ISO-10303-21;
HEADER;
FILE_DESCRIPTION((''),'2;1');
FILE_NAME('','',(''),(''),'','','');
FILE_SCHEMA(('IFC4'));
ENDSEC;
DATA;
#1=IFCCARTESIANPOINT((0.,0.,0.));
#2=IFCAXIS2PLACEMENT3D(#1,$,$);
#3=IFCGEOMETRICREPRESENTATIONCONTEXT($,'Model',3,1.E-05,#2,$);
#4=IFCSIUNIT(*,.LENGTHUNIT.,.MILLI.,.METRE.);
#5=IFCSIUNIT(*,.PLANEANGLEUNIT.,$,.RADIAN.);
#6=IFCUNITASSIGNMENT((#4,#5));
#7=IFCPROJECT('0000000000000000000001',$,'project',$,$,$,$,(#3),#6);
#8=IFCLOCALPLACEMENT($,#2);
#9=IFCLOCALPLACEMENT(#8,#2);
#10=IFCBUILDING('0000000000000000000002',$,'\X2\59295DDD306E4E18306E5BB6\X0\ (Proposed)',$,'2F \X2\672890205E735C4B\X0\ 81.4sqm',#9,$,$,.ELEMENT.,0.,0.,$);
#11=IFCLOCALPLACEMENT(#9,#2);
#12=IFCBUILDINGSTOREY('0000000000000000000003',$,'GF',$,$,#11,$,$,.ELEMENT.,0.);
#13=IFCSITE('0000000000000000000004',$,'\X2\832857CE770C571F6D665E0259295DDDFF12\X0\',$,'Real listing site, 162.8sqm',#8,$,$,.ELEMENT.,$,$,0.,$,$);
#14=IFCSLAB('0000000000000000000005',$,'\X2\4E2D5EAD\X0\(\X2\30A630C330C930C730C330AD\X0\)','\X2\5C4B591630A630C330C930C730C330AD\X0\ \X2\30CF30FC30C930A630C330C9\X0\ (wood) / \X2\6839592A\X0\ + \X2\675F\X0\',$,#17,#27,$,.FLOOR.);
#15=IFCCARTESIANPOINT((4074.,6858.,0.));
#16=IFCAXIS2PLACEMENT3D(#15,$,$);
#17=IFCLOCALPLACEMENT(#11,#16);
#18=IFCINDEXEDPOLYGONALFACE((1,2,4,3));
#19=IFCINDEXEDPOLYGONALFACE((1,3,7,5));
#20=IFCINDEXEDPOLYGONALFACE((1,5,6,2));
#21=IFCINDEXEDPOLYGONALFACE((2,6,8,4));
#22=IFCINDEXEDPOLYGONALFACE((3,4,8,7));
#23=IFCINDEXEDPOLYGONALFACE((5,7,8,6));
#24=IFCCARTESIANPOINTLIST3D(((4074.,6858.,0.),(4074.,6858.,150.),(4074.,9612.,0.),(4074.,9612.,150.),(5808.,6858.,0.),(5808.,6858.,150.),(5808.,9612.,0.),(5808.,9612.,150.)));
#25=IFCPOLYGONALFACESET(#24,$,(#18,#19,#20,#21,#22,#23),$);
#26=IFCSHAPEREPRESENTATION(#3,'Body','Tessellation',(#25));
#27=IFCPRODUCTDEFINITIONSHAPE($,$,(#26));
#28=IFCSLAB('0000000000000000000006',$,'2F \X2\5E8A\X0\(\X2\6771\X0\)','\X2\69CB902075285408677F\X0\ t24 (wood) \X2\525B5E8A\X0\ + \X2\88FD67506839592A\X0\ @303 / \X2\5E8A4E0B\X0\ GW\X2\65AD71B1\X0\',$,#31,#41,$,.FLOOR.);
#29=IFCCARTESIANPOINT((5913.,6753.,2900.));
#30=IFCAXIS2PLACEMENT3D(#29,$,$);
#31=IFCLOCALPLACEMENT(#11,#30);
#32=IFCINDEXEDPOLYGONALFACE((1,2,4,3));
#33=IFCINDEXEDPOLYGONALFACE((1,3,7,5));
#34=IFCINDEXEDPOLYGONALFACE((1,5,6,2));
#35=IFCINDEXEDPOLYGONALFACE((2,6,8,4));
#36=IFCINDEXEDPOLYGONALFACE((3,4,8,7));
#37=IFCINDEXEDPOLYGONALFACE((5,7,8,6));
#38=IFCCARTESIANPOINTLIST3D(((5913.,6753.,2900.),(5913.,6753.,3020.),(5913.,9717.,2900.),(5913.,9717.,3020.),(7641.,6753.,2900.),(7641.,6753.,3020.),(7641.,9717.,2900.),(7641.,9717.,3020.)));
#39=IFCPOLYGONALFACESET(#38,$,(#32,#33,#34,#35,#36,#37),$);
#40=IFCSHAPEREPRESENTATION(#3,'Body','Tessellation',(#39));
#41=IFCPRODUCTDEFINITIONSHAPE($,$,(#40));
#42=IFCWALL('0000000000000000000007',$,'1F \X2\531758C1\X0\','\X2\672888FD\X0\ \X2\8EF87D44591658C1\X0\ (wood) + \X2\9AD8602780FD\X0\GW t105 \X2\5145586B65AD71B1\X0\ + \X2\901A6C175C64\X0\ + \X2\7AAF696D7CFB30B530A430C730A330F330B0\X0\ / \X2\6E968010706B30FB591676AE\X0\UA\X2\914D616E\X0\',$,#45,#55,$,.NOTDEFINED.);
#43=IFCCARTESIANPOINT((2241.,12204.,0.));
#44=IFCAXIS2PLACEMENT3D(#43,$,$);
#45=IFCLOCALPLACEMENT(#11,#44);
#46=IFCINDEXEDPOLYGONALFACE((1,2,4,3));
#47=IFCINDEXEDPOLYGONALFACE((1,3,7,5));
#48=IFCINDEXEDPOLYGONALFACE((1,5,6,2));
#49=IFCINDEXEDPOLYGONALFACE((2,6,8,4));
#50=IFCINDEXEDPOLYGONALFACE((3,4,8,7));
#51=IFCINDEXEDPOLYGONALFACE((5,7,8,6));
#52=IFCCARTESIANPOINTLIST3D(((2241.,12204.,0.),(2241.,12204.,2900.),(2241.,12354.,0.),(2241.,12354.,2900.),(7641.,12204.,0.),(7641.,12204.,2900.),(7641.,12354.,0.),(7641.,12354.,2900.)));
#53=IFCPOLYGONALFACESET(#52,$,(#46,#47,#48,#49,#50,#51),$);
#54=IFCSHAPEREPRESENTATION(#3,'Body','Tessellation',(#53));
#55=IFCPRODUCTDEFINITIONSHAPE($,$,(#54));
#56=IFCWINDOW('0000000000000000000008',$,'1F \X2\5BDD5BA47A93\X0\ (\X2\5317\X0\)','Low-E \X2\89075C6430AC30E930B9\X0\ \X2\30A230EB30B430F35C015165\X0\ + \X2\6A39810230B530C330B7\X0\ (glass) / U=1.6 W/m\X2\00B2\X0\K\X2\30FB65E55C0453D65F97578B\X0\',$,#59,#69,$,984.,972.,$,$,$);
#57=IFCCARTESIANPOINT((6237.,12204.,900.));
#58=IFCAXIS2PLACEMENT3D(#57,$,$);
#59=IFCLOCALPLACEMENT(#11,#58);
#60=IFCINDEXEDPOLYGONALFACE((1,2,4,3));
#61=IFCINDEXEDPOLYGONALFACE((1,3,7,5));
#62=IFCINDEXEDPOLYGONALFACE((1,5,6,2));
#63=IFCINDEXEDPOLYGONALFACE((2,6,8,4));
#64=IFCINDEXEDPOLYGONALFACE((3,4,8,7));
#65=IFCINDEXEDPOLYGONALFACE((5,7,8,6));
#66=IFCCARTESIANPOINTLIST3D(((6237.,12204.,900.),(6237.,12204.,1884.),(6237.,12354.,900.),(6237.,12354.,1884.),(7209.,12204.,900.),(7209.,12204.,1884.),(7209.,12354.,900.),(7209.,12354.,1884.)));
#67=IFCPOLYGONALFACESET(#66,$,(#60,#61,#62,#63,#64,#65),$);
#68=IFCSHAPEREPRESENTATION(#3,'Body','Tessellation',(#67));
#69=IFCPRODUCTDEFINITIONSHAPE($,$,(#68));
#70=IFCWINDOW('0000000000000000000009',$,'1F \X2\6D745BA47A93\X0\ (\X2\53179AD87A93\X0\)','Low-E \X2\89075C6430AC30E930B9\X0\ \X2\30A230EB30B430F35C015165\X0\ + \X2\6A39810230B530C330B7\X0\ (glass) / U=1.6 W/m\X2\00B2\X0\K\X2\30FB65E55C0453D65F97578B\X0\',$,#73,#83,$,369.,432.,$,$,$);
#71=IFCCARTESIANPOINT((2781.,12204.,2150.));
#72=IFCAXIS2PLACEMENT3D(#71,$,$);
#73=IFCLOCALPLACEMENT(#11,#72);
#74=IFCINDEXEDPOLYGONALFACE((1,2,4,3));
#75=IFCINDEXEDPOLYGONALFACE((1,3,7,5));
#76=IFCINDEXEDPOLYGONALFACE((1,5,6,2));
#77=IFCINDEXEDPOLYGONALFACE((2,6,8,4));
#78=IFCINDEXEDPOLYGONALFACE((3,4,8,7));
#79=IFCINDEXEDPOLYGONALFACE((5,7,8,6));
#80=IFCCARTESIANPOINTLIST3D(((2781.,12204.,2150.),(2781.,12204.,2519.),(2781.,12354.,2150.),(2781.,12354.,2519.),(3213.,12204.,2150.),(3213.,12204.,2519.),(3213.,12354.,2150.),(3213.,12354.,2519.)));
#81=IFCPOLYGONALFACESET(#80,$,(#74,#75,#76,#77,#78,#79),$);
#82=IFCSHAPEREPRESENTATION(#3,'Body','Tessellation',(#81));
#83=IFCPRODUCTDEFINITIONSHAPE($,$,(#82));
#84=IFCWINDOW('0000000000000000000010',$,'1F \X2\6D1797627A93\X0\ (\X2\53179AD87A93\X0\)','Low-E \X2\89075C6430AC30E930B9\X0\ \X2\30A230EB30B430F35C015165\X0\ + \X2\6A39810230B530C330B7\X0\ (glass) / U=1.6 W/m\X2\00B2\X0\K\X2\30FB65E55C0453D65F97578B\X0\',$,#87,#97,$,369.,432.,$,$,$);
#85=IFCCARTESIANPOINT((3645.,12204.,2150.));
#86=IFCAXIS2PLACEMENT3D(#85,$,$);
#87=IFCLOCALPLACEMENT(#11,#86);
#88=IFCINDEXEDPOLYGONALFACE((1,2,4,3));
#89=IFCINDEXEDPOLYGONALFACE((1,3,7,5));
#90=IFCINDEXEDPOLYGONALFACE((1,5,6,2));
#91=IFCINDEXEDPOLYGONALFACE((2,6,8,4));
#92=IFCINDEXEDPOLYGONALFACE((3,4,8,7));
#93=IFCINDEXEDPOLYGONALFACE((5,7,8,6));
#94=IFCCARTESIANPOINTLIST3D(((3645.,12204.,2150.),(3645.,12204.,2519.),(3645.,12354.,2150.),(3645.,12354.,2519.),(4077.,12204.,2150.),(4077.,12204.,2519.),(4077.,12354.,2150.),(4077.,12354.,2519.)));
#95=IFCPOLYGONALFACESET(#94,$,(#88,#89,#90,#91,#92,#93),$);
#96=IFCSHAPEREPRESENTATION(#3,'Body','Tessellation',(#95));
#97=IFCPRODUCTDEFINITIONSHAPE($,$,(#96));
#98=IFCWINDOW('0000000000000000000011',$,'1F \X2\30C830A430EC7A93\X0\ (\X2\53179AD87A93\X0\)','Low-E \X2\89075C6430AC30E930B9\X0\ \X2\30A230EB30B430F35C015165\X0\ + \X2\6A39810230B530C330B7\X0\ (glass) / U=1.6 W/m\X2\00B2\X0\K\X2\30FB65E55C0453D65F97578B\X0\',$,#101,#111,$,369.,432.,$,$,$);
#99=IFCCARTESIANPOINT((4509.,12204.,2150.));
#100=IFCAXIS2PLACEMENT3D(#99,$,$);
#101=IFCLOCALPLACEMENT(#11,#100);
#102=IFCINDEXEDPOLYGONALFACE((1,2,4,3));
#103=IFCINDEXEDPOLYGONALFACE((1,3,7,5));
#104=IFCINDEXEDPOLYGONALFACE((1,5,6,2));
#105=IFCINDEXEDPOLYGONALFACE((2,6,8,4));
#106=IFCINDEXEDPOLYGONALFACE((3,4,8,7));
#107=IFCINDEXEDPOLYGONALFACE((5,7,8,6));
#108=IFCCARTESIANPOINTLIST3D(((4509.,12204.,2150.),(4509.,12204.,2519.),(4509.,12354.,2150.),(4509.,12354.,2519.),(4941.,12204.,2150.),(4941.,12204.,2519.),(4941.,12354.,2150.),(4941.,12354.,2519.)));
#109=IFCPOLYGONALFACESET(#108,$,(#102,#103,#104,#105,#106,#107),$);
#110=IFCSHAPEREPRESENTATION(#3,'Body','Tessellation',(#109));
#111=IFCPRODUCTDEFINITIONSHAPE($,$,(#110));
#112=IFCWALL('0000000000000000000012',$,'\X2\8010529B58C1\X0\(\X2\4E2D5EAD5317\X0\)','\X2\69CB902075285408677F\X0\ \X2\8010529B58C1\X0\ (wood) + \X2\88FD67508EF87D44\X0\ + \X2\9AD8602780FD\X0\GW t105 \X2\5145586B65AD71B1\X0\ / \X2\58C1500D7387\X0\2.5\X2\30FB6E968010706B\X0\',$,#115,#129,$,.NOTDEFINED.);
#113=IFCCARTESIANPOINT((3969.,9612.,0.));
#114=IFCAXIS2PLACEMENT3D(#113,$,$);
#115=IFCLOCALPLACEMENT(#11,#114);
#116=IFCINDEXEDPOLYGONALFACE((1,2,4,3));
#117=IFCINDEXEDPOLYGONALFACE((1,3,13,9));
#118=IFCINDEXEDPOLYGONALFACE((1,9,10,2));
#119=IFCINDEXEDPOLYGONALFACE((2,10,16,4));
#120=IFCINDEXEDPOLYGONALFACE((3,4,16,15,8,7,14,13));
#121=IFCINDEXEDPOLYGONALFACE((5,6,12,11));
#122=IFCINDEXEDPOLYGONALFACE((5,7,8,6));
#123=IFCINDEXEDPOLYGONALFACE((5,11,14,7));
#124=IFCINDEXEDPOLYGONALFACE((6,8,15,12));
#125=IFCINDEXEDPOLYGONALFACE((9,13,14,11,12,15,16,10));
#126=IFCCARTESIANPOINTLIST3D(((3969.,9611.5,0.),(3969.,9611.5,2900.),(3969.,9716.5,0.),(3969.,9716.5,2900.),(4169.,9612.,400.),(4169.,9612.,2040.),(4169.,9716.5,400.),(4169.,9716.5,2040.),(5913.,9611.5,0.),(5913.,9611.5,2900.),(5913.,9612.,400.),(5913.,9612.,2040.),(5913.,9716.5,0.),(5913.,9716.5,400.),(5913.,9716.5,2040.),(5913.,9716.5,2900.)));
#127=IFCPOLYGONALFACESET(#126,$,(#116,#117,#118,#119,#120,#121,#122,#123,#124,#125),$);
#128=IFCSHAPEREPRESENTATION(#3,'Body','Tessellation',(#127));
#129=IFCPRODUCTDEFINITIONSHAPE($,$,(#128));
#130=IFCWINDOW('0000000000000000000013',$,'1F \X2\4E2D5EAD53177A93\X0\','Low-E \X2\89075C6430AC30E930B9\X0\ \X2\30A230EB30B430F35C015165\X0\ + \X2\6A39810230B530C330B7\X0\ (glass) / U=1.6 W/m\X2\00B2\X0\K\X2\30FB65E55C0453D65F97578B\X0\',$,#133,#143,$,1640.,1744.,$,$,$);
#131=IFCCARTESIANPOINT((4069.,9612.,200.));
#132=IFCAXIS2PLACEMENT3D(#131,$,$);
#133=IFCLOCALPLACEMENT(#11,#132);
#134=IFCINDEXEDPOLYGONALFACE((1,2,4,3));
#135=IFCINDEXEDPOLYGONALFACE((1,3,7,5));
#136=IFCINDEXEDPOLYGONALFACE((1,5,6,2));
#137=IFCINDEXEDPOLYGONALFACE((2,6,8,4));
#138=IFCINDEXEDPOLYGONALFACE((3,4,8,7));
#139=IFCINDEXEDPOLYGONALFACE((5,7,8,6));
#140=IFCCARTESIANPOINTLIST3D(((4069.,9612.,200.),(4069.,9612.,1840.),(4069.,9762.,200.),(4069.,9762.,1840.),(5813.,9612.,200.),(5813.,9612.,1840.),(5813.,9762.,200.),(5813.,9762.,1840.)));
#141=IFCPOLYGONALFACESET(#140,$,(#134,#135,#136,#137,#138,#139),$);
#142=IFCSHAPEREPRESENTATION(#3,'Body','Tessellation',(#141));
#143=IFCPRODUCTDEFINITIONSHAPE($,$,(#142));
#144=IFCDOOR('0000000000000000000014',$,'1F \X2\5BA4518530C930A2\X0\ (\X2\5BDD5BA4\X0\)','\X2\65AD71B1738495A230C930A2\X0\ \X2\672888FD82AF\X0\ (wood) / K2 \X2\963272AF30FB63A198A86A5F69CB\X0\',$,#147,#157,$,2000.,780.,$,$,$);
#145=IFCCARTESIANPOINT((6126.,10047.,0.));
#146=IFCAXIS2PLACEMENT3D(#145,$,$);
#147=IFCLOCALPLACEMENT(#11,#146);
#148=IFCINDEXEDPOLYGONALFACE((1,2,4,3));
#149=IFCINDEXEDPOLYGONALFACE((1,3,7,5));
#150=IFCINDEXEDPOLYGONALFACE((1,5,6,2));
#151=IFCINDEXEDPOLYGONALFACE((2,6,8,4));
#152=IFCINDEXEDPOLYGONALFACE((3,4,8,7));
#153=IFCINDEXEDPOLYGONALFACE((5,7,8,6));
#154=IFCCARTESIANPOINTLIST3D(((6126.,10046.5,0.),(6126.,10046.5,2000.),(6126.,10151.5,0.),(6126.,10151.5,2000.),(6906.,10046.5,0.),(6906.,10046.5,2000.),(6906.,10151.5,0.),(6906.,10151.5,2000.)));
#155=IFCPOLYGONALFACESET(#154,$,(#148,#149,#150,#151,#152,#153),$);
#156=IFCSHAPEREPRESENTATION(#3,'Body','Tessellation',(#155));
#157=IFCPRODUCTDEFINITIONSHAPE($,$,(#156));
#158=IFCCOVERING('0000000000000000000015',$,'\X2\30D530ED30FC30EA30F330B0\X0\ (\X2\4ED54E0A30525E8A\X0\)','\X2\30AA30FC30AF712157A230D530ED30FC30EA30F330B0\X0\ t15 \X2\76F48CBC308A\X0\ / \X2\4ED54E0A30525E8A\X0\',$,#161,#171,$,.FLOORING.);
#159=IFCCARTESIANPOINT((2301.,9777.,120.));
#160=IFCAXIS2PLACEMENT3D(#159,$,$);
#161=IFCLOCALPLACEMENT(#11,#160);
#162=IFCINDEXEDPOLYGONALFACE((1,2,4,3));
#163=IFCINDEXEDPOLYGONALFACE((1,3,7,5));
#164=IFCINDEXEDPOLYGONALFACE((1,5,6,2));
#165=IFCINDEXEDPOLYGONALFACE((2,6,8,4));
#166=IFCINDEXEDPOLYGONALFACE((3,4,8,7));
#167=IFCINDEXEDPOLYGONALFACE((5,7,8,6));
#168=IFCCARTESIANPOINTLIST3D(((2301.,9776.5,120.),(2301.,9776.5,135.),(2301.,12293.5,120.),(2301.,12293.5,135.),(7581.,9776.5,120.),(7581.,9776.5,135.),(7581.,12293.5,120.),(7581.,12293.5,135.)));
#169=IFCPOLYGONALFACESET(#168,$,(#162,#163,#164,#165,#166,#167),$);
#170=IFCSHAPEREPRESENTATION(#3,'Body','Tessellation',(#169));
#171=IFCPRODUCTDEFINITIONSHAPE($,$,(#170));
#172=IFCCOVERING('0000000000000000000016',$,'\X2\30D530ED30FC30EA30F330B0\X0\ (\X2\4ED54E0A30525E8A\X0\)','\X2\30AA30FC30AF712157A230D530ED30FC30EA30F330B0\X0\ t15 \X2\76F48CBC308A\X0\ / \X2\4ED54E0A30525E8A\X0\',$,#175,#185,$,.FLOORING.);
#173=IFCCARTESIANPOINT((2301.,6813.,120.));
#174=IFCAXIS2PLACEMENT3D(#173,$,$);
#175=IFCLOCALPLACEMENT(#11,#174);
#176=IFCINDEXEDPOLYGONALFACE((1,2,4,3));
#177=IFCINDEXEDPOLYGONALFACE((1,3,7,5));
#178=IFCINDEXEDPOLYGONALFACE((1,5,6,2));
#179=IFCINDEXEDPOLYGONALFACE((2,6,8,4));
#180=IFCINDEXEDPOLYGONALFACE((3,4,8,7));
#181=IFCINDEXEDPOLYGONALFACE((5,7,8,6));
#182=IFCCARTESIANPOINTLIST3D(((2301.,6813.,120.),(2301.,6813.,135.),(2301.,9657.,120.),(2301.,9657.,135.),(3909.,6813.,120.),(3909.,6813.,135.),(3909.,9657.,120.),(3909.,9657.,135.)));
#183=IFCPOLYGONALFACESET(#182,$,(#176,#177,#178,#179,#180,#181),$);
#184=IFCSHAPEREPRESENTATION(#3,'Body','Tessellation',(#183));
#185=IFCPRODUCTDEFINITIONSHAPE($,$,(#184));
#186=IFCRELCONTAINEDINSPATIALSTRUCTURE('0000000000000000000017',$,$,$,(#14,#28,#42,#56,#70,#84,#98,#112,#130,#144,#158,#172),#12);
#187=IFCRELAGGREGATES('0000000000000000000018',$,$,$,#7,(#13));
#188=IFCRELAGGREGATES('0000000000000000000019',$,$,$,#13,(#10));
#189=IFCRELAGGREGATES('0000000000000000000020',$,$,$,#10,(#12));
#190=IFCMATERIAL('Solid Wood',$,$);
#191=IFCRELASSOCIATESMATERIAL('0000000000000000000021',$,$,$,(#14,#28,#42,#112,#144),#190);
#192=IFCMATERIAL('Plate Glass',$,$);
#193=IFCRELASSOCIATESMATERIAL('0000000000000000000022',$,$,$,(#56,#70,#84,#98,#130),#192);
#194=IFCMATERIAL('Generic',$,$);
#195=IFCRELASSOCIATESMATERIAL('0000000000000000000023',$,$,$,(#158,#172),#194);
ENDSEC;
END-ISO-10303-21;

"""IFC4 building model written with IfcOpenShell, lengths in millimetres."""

from ifc_helpers import new_model, si_unit, frame, frame_2d, origin, place, context, project, spatial, rectangle, extrude, material, element, fill, save


model = new_model("IFC4")

# Units and contexts
model_context = context("Model", 3, precision=1e-05, world=origin())
ifc_project = project(units=[si_unit("LENGTHUNIT", "METRE", prefix="MILLI"), si_unit("PLANEANGLEUNIT", "RADIAN")], contexts=[model_context])

# Site, building, storey
site_placement = place(None, origin())
site = spatial("IfcSite", under=ifc_project, at=site_placement, Name="茨城県土浦市天川２", ObjectType="Real listing site, 162.8sqm", CompositionType="ELEMENT", RefElevation=0.0)
building_placement = place(site_placement, origin())
building = spatial("IfcBuilding", under=site, at=building_placement, Name="天川の丘の家 (Proposed)", ObjectType="2F 木造平屋 81.4sqm", CompositionType="ELEMENT", ElevationOfRefHeight=0.0, ElevationOfTerrain=0.0)
storey_placement = place(building_placement, origin())
storey = spatial("IfcBuildingStorey", under=building, at=storey_placement, Name="GF", CompositionType="ELEMENT", Elevation=0.0)

# Slabs
ifc_material_1 = material(Name="Solid Wood")
slab_1_placement = place(storey_placement, frame((4074.0, 6858.0, 0.0)))
element("IfcSlab", 1, at=slab_1_placement, inside=storey, material=ifc_material_1, Name="中庭(ウッドデッキ)", Description="屋外ウッドデッキ ハードウッド (wood) / 根太 + 束", PredefinedType="FLOOR", context=model_context, shape_type="SweptSolid", body=[
    extrude(rectangle(XDim=1734.0, YDim=2754.0, at=frame_2d((867.0, 1377.0))), frame((4074.0, 6858.0, 0.0)), (0.0, 0.0, 1.0), 150.0),
])
slab_2_placement = place(storey_placement, frame((5913.0, 6753.0, 2900.0)))
element("IfcSlab", 2, at=slab_2_placement, inside=storey, material=ifc_material_1, Name="2F 床(東)", Description="構造用合板 t24 (wood) 剛床 + 製材根太 @303 / 床下 GW断熱", PredefinedType="FLOOR", context=model_context, shape_type="SweptSolid", body=[
    extrude(rectangle(XDim=1728.0, YDim=2964.0, at=frame_2d((864.0, 1482.0))), frame((5913.0, 6753.0, 2900.0)), (0.0, 0.0, 1.0), 120.0),
])

# Wall, openings, windows
wall_1_placement = place(storey_placement, frame((2241.0, 12204.0, 0.0)))
wall_1 = element("IfcWall", 3, at=wall_1_placement, inside=storey, material=ifc_material_1, Name="1F 北壁", Description="木製 軸組外壁 (wood) + 高性能GW t105 充填断熱 + 通気層 + 窯業系サイディング / 準耐火・外皮UA配慮", PredefinedType="NOTDEFINED", context=model_context, shape_type="SweptSolid", body=[
    extrude(rectangle(XDim=5400.0, YDim=150.0, at=frame_2d((2700.0, 75.0))), frame((2241.0, 12204.0, 0.0)), (0.0, 0.0, 1.0), 2900.0),
])
opening_1_placement = place(storey_placement, frame((6237.0, 12204.0, 900.0)))
opening_1 = element("IfcOpeningElement", 4, at=opening_1_placement, cuts=wall_1, PredefinedType="NOTDEFINED", context=model_context, shape_type="SweptSolid", body=[
    extrude(rectangle(XDim=972.0, YDim=150.0, at=frame_2d((486.0, 75.0))), frame((6237.0, 12204.0, 900.0)), (0.0, 0.0, 1.0), 984.0),
])
opening_2_placement = place(storey_placement, frame((2781.0, 12204.0, 2150.0)))
opening_2 = element("IfcOpeningElement", 5, at=opening_2_placement, cuts=wall_1, PredefinedType="NOTDEFINED", context=model_context, shape_type="SweptSolid", body=[
    extrude(rectangle(XDim=432.0, YDim=150.0, at=frame_2d((216.0, 75.0))), frame((2781.0, 12204.0, 2150.0)), (0.0, 0.0, 1.0), 369.0),
])
opening_3_placement = place(storey_placement, frame((3645.0, 12204.0, 2150.0)))
opening_3 = element("IfcOpeningElement", 6, at=opening_3_placement, cuts=wall_1, PredefinedType="NOTDEFINED", context=model_context, shape_type="SweptSolid", body=[
    extrude(rectangle(XDim=432.0, YDim=150.0, at=frame_2d((216.0, 75.0))), frame((3645.0, 12204.0, 2150.0)), (0.0, 0.0, 1.0), 369.0),
])
opening_4_placement = place(storey_placement, frame((4509.0, 12204.0, 2150.0)))
opening_4 = element("IfcOpeningElement", 7, at=opening_4_placement, cuts=wall_1, PredefinedType="NOTDEFINED", context=model_context, shape_type="SweptSolid", body=[
    extrude(rectangle(XDim=432.0, YDim=150.0, at=frame_2d((216.0, 75.0))), frame((4509.0, 12204.0, 2150.0)), (0.0, 0.0, 1.0), 369.0),
])
ifc_material_2 = material(Name="Plate Glass")
window_1_placement = place(storey_placement, frame((6237.0, 12204.0, 900.0)))
window_1 = element("IfcWindow", 8, at=window_1_placement, inside=storey, material=ifc_material_2, Name="1F 寝室窓 (北)", Description="Low-E 複層ガラス アルゴン封入 + 樹脂サッシ (glass) / U=1.6 W/m²K・日射取得型", OverallHeight=984.0, OverallWidth=972.0, context=model_context, shape_type="SweptSolid", body=[
    extrude(rectangle(XDim=972.0, YDim=150.0, at=frame_2d((486.0, 75.0))), frame((6237.0, 12204.0, 900.0)), (0.0, 0.0, 1.0), 984.0),
])
fill(opening_1, window_1)
window_2_placement = place(storey_placement, frame((2781.0, 12204.0, 2150.0)))
window_2 = element("IfcWindow", 9, at=window_2_placement, inside=storey, material=ifc_material_2, Name="1F 浴室窓 (北高窓)", Description="Low-E 複層ガラス アルゴン封入 + 樹脂サッシ (glass) / U=1.6 W/m²K・日射取得型", OverallHeight=369.0, OverallWidth=432.0, context=model_context, shape_type="SweptSolid", body=[
    extrude(rectangle(XDim=432.0, YDim=150.0, at=frame_2d((216.0, 75.0))), frame((2781.0, 12204.0, 2150.0)), (0.0, 0.0, 1.0), 369.0),
])
fill(opening_2, window_2)
window_3_placement = place(storey_placement, frame((3645.0, 12204.0, 2150.0)))
window_3 = element("IfcWindow", 10, at=window_3_placement, inside=storey, material=ifc_material_2, Name="1F 洗面窓 (北高窓)", Description="Low-E 複層ガラス アルゴン封入 + 樹脂サッシ (glass) / U=1.6 W/m²K・日射取得型", OverallHeight=369.0, OverallWidth=432.0, context=model_context, shape_type="SweptSolid", body=[
    extrude(rectangle(XDim=432.0, YDim=150.0, at=frame_2d((216.0, 75.0))), frame((3645.0, 12204.0, 2150.0)), (0.0, 0.0, 1.0), 369.0),
])
fill(opening_3, window_3)
window_4_placement = place(storey_placement, frame((4509.0, 12204.0, 2150.0)))
window_4 = element("IfcWindow", 11, at=window_4_placement, inside=storey, material=ifc_material_2, Name="1F トイレ窓 (北高窓)", Description="Low-E 複層ガラス アルゴン封入 + 樹脂サッシ (glass) / U=1.6 W/m²K・日射取得型", OverallHeight=369.0, OverallWidth=432.0, context=model_context, shape_type="SweptSolid", body=[
    extrude(rectangle(XDim=432.0, YDim=150.0, at=frame_2d((216.0, 75.0))), frame((4509.0, 12204.0, 2150.0)), (0.0, 0.0, 1.0), 369.0),
])
fill(opening_4, window_4)

# Wall, opening, window
wall_2_placement = place(storey_placement, frame((3969.0, 9612.0, 0.0)))
wall_2 = element("IfcWall", 12, at=wall_2_placement, inside=storey, material=ifc_material_1, Name="耐力壁(中庭北)", Description="構造用合板 耐力壁 (wood) + 製材軸組 + 高性能GW t105 充填断熱 / 壁倍率2.5・準耐火", PredefinedType="NOTDEFINED", context=model_context, shape_type="SweptSolid", body=[
    extrude(rectangle(XDim=1944.0, YDim=105.0, at=frame_2d((972.0, 52.0))), frame((3969.0, 9612.0, 0.0)), (0.0, 0.0, 1.0), 2900.0),
])
opening_5_placement = place(storey_placement, frame((4069.0, 9612.0, 200.0)))
opening_5 = element("IfcOpeningElement", 13, at=opening_5_placement, cuts=wall_2, PredefinedType="NOTDEFINED", context=model_context, shape_type="SweptSolid", body=[
    extrude(rectangle(XDim=1744.0, YDim=150.0, at=frame_2d((872.0, 75.0))), frame((4069.0, 9612.0, 200.0)), (0.0, 0.0, 1.0), 1640.0),
])
window_5_placement = place(storey_placement, frame((4069.0, 9612.0, 200.0)))
window_5 = element("IfcWindow", 14, at=window_5_placement, inside=storey, material=ifc_material_2, Name="1F 中庭北窓", Description="Low-E 複層ガラス アルゴン封入 + 樹脂サッシ (glass) / U=1.6 W/m²K・日射取得型", OverallHeight=1640.0, OverallWidth=1744.0, context=model_context, shape_type="SweptSolid", body=[
    extrude(rectangle(XDim=1744.0, YDim=150.0, at=frame_2d((872.0, 75.0))), frame((4069.0, 9612.0, 200.0)), (0.0, 0.0, 1.0), 1640.0),
])
fill(opening_5, window_5)

# Door
door_1_placement = place(storey_placement, frame((6126.0, 10047.0, 0.0)))
element("IfcDoor", 15, at=door_1_placement, inside=storey, material=ifc_material_1, Name="1F 室内ドア (寝室)", Description="断熱玄関ドア 木製芯 (wood) / K2 防犯・採風機構", OverallHeight=2000.0, OverallWidth=780.0, context=model_context, shape_type="SweptSolid", body=[
    extrude(rectangle(XDim=780.0, YDim=105.0, at=frame_2d((390.0, 52.0))), frame((6126.0, 10047.0, 0.0)), (0.0, 0.0, 1.0), 2000.0),
])

# Coverings
ifc_material_3 = material(Name="Generic")
covering_1_placement = place(storey_placement, frame((2301.0, 9777.0, 120.0)))
element("IfcCovering", 16, at=covering_1_placement, inside=storey, material=ifc_material_3, Name="フローリング (仕上げ床)", Description="オーク無垢フローリング t15 直貼り / 仕上げ床", PredefinedType="FLOORING", context=model_context, shape_type="SweptSolid", body=[
    extrude(rectangle(XDim=5280.0, YDim=2517.0, at=frame_2d((2640.0, 1258.0))), frame((2301.0, 9777.0, 120.0)), (0.0, 0.0, 1.0), 15.0),
])
covering_2_placement = place(storey_placement, frame((2301.0, 6813.0, 120.0)))
element("IfcCovering", 17, at=covering_2_placement, inside=storey, material=ifc_material_3, Name="フローリング (仕上げ床)", Description="オーク無垢フローリング t15 直貼り / 仕上げ床", PredefinedType="FLOORING", context=model_context, shape_type="SweptSolid", body=[
    extrude(rectangle(XDim=1608.0, YDim=2844.0, at=frame_2d((804.0, 1422.0))), frame((2301.0, 6813.0, 120.0)), (0.0, 0.0, 1.0), 15.0),
])

save(model, "model.ifc")
